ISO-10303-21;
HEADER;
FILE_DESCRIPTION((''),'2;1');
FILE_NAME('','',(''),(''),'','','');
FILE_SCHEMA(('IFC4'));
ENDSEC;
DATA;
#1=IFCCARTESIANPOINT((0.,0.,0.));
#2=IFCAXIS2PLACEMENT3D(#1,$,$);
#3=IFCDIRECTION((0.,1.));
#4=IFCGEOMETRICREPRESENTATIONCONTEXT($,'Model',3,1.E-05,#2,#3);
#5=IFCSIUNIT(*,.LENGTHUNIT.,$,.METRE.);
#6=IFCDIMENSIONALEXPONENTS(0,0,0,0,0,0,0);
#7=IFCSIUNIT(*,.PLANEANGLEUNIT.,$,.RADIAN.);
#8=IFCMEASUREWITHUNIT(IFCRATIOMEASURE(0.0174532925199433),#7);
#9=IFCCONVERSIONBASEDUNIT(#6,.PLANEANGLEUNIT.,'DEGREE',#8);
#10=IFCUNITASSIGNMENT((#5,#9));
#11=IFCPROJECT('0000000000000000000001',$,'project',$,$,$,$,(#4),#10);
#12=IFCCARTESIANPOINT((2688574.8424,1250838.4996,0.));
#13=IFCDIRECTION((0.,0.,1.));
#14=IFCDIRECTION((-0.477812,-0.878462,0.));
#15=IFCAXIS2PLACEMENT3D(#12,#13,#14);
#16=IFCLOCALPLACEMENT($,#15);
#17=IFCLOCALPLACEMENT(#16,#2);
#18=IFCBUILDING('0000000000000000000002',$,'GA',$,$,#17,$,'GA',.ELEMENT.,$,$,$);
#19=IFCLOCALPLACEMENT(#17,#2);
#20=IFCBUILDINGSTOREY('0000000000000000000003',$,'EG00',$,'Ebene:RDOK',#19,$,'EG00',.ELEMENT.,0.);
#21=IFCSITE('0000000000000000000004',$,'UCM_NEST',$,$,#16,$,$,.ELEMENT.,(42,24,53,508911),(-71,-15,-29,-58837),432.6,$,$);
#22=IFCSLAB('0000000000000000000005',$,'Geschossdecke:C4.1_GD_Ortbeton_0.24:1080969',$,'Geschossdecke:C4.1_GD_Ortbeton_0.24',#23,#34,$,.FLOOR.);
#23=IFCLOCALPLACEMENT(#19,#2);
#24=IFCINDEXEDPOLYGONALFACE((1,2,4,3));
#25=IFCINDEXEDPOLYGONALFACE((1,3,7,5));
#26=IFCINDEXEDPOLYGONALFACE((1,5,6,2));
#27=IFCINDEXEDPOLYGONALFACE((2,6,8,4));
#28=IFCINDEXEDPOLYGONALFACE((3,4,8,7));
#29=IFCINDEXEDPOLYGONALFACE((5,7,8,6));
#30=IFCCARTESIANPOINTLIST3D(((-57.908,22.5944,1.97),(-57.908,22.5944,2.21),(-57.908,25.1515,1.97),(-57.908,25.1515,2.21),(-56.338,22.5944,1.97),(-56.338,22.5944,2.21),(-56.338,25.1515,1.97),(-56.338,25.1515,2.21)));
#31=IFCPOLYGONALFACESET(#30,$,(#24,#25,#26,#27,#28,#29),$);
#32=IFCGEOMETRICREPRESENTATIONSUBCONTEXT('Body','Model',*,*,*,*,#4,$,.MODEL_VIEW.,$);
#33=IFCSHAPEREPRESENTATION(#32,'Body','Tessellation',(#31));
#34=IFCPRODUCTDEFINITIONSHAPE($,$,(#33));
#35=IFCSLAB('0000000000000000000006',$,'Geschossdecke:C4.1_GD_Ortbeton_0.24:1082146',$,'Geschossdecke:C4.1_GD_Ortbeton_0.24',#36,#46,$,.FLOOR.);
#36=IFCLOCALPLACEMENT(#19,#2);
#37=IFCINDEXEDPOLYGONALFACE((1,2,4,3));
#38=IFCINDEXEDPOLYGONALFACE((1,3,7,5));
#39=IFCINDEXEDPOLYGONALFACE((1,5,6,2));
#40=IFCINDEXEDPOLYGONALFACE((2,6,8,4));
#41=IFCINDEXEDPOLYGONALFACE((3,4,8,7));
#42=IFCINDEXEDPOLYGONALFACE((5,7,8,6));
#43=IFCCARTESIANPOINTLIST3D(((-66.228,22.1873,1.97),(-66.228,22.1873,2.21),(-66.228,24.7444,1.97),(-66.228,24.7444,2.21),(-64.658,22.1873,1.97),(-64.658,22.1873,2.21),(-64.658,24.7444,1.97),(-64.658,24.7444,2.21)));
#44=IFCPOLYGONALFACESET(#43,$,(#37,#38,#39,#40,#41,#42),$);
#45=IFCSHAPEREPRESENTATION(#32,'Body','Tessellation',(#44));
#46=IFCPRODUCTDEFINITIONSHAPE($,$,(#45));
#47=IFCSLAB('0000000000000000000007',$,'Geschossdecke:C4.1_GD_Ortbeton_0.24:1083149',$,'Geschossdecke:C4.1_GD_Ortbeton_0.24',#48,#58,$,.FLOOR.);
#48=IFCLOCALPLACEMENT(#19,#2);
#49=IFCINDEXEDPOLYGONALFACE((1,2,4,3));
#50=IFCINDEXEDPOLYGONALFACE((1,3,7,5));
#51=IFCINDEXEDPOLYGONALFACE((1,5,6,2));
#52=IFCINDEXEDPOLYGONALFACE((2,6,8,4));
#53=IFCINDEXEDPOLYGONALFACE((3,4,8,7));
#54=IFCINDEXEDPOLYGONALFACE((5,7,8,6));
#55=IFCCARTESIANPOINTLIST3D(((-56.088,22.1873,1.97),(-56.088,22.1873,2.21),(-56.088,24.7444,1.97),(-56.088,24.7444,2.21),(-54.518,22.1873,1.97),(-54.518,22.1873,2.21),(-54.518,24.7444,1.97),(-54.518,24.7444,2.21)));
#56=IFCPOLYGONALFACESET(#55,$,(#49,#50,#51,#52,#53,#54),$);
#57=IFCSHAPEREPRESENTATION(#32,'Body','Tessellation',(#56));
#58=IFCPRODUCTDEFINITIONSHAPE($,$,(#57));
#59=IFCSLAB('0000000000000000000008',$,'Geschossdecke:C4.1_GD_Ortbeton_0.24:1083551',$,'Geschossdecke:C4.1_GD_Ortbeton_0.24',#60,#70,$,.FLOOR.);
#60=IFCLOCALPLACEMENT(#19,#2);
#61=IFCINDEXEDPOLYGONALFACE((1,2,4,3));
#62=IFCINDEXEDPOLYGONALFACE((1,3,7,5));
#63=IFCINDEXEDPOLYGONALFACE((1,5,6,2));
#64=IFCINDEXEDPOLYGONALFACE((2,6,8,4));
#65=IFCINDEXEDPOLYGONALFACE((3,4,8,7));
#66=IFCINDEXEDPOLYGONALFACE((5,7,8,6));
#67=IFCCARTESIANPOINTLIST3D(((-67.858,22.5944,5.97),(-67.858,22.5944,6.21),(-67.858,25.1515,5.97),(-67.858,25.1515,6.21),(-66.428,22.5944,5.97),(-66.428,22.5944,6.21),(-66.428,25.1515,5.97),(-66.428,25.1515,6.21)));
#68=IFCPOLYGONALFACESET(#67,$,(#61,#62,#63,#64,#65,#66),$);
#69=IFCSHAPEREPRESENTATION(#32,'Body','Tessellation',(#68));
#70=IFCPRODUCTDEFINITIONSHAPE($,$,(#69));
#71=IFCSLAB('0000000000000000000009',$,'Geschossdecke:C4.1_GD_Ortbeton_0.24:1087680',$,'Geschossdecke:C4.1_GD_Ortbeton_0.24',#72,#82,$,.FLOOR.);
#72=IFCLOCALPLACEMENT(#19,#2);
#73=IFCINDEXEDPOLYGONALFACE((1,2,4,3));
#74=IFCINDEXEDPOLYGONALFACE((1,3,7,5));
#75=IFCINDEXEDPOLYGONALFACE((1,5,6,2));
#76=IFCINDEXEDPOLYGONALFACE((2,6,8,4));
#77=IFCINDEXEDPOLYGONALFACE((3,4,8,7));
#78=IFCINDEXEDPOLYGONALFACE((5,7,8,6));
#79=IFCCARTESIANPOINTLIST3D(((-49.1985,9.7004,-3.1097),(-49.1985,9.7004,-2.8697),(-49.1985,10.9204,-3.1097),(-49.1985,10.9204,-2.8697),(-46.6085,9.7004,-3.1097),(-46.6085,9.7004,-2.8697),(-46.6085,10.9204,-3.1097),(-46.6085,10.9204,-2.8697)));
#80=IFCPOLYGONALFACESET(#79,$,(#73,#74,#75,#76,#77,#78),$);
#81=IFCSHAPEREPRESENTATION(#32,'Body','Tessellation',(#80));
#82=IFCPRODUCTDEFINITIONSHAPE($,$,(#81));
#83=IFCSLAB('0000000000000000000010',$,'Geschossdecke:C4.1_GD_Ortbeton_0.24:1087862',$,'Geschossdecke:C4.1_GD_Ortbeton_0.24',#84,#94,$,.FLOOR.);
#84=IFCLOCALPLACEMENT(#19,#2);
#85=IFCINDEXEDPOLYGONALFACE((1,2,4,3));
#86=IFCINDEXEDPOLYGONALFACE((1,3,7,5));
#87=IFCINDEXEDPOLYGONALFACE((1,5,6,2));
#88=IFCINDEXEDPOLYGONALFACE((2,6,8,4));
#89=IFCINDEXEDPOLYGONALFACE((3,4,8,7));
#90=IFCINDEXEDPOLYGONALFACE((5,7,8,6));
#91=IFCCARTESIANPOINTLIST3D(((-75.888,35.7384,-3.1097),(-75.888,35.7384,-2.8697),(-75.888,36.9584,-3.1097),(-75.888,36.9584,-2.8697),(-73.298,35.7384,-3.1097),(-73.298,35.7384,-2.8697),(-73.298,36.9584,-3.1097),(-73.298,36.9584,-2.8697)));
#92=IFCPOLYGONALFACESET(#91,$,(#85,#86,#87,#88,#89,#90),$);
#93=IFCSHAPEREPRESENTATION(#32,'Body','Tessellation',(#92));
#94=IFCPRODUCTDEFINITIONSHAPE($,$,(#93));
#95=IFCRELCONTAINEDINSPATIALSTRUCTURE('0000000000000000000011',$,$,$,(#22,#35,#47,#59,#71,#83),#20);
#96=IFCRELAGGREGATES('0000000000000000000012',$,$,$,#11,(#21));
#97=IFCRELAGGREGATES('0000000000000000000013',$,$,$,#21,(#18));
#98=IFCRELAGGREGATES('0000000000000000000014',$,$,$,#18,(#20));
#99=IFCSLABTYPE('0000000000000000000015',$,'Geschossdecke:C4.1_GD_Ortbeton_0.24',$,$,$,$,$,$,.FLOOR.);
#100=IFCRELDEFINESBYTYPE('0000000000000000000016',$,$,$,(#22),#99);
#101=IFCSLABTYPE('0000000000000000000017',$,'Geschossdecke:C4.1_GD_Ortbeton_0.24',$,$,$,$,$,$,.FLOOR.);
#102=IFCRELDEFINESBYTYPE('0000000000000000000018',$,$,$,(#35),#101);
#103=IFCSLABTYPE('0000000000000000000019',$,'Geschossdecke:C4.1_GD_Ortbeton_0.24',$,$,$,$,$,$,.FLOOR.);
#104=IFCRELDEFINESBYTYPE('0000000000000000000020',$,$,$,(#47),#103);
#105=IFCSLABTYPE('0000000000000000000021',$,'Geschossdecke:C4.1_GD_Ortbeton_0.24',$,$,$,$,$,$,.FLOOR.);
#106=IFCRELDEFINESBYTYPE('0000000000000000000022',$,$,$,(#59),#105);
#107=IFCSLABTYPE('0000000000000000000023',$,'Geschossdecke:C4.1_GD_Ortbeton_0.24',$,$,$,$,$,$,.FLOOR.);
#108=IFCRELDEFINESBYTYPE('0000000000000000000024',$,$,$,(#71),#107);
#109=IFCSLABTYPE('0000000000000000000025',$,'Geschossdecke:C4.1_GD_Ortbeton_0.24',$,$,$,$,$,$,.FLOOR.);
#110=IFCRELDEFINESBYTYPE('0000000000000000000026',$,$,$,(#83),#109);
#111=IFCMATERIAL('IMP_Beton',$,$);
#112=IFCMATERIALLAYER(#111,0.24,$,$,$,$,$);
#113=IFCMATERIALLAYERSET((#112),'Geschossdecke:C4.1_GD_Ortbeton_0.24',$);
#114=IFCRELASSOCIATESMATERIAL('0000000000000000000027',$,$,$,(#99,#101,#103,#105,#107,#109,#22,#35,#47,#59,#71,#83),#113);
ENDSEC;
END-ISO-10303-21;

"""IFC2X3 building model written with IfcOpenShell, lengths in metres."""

from ifc_helpers import new_model, entity, si_unit, converted_unit, direction, frame, frame_2d, origin, place, context, subcontext, project, spatial, rectangle, extrude, material, layer, layer_set, layer_usage, type_object, element, save


model = new_model("IFC2X3")

# Units and contexts
model_context = context("Model", 3, precision=1e-05, world=origin(), true_north=direction((0.0, 1.0)))
body_context = subcontext(model_context, "Body", "Model", "MODEL_VIEW")
ifc_project = project(units=[si_unit("LENGTHUNIT", "METRE"), converted_unit("PLANEANGLEUNIT", "DEGREE", entity("IfcRatioMeasure", 0.0174532925199433), si_unit("PLANEANGLEUNIT", "RADIAN"), dimensions=[0, 0, 0, 0, 0, 0, 0])], contexts=[model_context])

# Site, building, storey
site_placement = place(None, frame((2688574.8424, 1250838.4996, 0.0), z_axis=(0.0, 0.0, 1.0), x_axis=(-0.477812, -0.878462, 0.0)))
site = spatial("IfcSite", under=ifc_project, at=site_placement, Name="UCM_NEST", CompositionType="ELEMENT", RefLatitude=(42, 24, 53, 508911), RefLongitude=(-71, -15, -29, -58837), RefElevation=432.6)
building_placement = place(site_placement, origin())
building = spatial("IfcBuilding", under=site, at=building_placement, Name="GA", LongName="GA", CompositionType="ELEMENT")
storey_placement = place(building_placement, origin())
storey = spatial("IfcBuildingStorey", under=building, at=storey_placement, Name="EG00", ObjectType="Ebene:RDOK", LongName="EG00", CompositionType="ELEMENT", Elevation=0.0)

# Shared definitions
ifc_material_1 = material(Name="IMP_Beton")

# Slabs
ifc_layer_1 = layer(ifc_material_1, 0.24)
ifc_layer_set_1 = layer_set([ifc_layer_1], Name="Geschossdecke:C4.1_GD_Ortbeton_0.24")
ifc_layer_usage_1 = layer_usage(ifc_layer_set_1, "AXIS3", "POSITIVE", 0.0)
slab_type_1 = type_object("IfcSlabType", Name="Geschossdecke:C4.1_GD_Ortbeton_0.24", PredefinedType="FLOOR", material=ifc_layer_set_1)
slab_1_placement = place(storey_placement, origin())
element("IfcSlab", 1, at=slab_1_placement, inside=storey, type_object=slab_type_1, material=ifc_layer_usage_1, Name="Geschossdecke:C4.1_GD_Ortbeton_0.24:1080969", ObjectType="Geschossdecke:C4.1_GD_Ortbeton_0.24", PredefinedType="FLOOR", context=body_context, shape_type="SweptSolid", body=[
    extrude(rectangle(XDim=2.5571, YDim=1.57, at=frame_2d((0.0, 0.0), x_axis=(1.0, 0.0))), frame((-57.123, 23.873, 2.21), z_axis=(0.0, 0.0, -1.0), x_axis=(0.0, 1.0, 0.0)), (0.0, 0.0, 1.0), 0.24),
])
ifc_layer_usage_2 = layer_usage(ifc_layer_set_1, "AXIS3", "POSITIVE", 0.0)
slab_type_2 = type_object("IfcSlabType", Name="Geschossdecke:C4.1_GD_Ortbeton_0.24", PredefinedType="FLOOR", material=ifc_layer_set_1)
slab_2_placement = place(storey_placement, origin())
element("IfcSlab", 2, at=slab_2_placement, inside=storey, type_object=slab_type_2, material=ifc_layer_usage_2, Name="Geschossdecke:C4.1_GD_Ortbeton_0.24:1082146", ObjectType="Geschossdecke:C4.1_GD_Ortbeton_0.24", PredefinedType="FLOOR", context=body_context, shape_type="SweptSolid", body=[
    extrude(rectangle(XDim=2.5571, YDim=1.57, at=frame_2d((0.0, 0.0), x_axis=(1.0, 0.0))), frame((-65.443, 23.4659, 2.21), z_axis=(0.0, 0.0, -1.0), x_axis=(0.0, 1.0, 0.0)), (0.0, 0.0, 1.0), 0.24),
])
ifc_layer_usage_3 = layer_usage(ifc_layer_set_1, "AXIS3", "POSITIVE", 0.0)
slab_type_3 = type_object("IfcSlabType", Name="Geschossdecke:C4.1_GD_Ortbeton_0.24", PredefinedType="FLOOR", material=ifc_layer_set_1)
slab_3_placement = place(storey_placement, origin())
element("IfcSlab", 3, at=slab_3_placement, inside=storey, type_object=slab_type_3, material=ifc_layer_usage_3, Name="Geschossdecke:C4.1_GD_Ortbeton_0.24:1083149", ObjectType="Geschossdecke:C4.1_GD_Ortbeton_0.24", PredefinedType="FLOOR", context=body_context, shape_type="SweptSolid", body=[
    extrude(rectangle(XDim=2.5571, YDim=1.57, at=frame_2d((0.0, 0.0), x_axis=(1.0, 0.0))), frame((-55.303, 23.4659, 2.21), z_axis=(0.0, 0.0, -1.0), x_axis=(0.0, 1.0, 0.0)), (0.0, 0.0, 1.0), 0.24),
])
ifc_layer_usage_4 = layer_usage(ifc_layer_set_1, "AXIS3", "POSITIVE", 0.0)
slab_type_4 = type_object("IfcSlabType", Name="Geschossdecke:C4.1_GD_Ortbeton_0.24", PredefinedType="FLOOR", material=ifc_layer_set_1)
slab_4_placement = place(storey_placement, origin())
element("IfcSlab", 4, at=slab_4_placement, inside=storey, type_object=slab_type_4, material=ifc_layer_usage_4, Name="Geschossdecke:C4.1_GD_Ortbeton_0.24:1083551", ObjectType="Geschossdecke:C4.1_GD_Ortbeton_0.24", PredefinedType="FLOOR", context=body_context, shape_type="SweptSolid", body=[
    extrude(rectangle(XDim=2.5571, YDim=1.43, at=frame_2d((0.0, 0.0), x_axis=(1.0, 0.0))), frame((-67.143, 23.873, 6.21), z_axis=(0.0, 0.0, -1.0), x_axis=(0.0, 1.0, 0.0)), (0.0, 0.0, 1.0), 0.24),
])
ifc_layer_usage_5 = layer_usage(ifc_layer_set_1, "AXIS3", "POSITIVE", 0.0)
slab_type_5 = type_object("IfcSlabType", Name="Geschossdecke:C4.1_GD_Ortbeton_0.24", PredefinedType="FLOOR", material=ifc_layer_set_1)
slab_5_placement = place(storey_placement, origin())
element("IfcSlab", 5, at=slab_5_placement, inside=storey, type_object=slab_type_5, material=ifc_layer_usage_5, Name="Geschossdecke:C4.1_GD_Ortbeton_0.24:1087680", ObjectType="Geschossdecke:C4.1_GD_Ortbeton_0.24", PredefinedType="FLOOR", context=body_context, shape_type="SweptSolid", body=[
    extrude(rectangle(XDim=1.22, YDim=2.59, at=frame_2d((0.0, 0.0), x_axis=(1.0, 0.0))), frame((-47.9035, 10.3104, -2.8697), z_axis=(0.0, 0.0, -1.0), x_axis=(0.0, 1.0, 0.0)), (0.0, 0.0, 1.0), 0.24),
])
ifc_layer_usage_6 = layer_usage(ifc_layer_set_1, "AXIS3", "POSITIVE", 0.0)
slab_type_6 = type_object("IfcSlabType", Name="Geschossdecke:C4.1_GD_Ortbeton_0.24", PredefinedType="FLOOR", material=ifc_layer_set_1)
slab_6_placement = place(storey_placement, origin())
element("IfcSlab", 6, at=slab_6_placement, inside=storey, type_object=slab_type_6, material=ifc_layer_usage_6, Name="Geschossdecke:C4.1_GD_Ortbeton_0.24:1087862", ObjectType="Geschossdecke:C4.1_GD_Ortbeton_0.24", PredefinedType="FLOOR", context=body_context, shape_type="SweptSolid", body=[
    extrude(rectangle(XDim=1.22, YDim=2.59, at=frame_2d((0.0, 0.0), x_axis=(1.0, 0.0))), frame((-74.593, 36.3484, -2.8697), z_axis=(0.0, 0.0, -1.0), x_axis=(0.0, 1.0, 0.0)), (0.0, 0.0, 1.0), 0.24),
])

save(model, "model.ifc")
